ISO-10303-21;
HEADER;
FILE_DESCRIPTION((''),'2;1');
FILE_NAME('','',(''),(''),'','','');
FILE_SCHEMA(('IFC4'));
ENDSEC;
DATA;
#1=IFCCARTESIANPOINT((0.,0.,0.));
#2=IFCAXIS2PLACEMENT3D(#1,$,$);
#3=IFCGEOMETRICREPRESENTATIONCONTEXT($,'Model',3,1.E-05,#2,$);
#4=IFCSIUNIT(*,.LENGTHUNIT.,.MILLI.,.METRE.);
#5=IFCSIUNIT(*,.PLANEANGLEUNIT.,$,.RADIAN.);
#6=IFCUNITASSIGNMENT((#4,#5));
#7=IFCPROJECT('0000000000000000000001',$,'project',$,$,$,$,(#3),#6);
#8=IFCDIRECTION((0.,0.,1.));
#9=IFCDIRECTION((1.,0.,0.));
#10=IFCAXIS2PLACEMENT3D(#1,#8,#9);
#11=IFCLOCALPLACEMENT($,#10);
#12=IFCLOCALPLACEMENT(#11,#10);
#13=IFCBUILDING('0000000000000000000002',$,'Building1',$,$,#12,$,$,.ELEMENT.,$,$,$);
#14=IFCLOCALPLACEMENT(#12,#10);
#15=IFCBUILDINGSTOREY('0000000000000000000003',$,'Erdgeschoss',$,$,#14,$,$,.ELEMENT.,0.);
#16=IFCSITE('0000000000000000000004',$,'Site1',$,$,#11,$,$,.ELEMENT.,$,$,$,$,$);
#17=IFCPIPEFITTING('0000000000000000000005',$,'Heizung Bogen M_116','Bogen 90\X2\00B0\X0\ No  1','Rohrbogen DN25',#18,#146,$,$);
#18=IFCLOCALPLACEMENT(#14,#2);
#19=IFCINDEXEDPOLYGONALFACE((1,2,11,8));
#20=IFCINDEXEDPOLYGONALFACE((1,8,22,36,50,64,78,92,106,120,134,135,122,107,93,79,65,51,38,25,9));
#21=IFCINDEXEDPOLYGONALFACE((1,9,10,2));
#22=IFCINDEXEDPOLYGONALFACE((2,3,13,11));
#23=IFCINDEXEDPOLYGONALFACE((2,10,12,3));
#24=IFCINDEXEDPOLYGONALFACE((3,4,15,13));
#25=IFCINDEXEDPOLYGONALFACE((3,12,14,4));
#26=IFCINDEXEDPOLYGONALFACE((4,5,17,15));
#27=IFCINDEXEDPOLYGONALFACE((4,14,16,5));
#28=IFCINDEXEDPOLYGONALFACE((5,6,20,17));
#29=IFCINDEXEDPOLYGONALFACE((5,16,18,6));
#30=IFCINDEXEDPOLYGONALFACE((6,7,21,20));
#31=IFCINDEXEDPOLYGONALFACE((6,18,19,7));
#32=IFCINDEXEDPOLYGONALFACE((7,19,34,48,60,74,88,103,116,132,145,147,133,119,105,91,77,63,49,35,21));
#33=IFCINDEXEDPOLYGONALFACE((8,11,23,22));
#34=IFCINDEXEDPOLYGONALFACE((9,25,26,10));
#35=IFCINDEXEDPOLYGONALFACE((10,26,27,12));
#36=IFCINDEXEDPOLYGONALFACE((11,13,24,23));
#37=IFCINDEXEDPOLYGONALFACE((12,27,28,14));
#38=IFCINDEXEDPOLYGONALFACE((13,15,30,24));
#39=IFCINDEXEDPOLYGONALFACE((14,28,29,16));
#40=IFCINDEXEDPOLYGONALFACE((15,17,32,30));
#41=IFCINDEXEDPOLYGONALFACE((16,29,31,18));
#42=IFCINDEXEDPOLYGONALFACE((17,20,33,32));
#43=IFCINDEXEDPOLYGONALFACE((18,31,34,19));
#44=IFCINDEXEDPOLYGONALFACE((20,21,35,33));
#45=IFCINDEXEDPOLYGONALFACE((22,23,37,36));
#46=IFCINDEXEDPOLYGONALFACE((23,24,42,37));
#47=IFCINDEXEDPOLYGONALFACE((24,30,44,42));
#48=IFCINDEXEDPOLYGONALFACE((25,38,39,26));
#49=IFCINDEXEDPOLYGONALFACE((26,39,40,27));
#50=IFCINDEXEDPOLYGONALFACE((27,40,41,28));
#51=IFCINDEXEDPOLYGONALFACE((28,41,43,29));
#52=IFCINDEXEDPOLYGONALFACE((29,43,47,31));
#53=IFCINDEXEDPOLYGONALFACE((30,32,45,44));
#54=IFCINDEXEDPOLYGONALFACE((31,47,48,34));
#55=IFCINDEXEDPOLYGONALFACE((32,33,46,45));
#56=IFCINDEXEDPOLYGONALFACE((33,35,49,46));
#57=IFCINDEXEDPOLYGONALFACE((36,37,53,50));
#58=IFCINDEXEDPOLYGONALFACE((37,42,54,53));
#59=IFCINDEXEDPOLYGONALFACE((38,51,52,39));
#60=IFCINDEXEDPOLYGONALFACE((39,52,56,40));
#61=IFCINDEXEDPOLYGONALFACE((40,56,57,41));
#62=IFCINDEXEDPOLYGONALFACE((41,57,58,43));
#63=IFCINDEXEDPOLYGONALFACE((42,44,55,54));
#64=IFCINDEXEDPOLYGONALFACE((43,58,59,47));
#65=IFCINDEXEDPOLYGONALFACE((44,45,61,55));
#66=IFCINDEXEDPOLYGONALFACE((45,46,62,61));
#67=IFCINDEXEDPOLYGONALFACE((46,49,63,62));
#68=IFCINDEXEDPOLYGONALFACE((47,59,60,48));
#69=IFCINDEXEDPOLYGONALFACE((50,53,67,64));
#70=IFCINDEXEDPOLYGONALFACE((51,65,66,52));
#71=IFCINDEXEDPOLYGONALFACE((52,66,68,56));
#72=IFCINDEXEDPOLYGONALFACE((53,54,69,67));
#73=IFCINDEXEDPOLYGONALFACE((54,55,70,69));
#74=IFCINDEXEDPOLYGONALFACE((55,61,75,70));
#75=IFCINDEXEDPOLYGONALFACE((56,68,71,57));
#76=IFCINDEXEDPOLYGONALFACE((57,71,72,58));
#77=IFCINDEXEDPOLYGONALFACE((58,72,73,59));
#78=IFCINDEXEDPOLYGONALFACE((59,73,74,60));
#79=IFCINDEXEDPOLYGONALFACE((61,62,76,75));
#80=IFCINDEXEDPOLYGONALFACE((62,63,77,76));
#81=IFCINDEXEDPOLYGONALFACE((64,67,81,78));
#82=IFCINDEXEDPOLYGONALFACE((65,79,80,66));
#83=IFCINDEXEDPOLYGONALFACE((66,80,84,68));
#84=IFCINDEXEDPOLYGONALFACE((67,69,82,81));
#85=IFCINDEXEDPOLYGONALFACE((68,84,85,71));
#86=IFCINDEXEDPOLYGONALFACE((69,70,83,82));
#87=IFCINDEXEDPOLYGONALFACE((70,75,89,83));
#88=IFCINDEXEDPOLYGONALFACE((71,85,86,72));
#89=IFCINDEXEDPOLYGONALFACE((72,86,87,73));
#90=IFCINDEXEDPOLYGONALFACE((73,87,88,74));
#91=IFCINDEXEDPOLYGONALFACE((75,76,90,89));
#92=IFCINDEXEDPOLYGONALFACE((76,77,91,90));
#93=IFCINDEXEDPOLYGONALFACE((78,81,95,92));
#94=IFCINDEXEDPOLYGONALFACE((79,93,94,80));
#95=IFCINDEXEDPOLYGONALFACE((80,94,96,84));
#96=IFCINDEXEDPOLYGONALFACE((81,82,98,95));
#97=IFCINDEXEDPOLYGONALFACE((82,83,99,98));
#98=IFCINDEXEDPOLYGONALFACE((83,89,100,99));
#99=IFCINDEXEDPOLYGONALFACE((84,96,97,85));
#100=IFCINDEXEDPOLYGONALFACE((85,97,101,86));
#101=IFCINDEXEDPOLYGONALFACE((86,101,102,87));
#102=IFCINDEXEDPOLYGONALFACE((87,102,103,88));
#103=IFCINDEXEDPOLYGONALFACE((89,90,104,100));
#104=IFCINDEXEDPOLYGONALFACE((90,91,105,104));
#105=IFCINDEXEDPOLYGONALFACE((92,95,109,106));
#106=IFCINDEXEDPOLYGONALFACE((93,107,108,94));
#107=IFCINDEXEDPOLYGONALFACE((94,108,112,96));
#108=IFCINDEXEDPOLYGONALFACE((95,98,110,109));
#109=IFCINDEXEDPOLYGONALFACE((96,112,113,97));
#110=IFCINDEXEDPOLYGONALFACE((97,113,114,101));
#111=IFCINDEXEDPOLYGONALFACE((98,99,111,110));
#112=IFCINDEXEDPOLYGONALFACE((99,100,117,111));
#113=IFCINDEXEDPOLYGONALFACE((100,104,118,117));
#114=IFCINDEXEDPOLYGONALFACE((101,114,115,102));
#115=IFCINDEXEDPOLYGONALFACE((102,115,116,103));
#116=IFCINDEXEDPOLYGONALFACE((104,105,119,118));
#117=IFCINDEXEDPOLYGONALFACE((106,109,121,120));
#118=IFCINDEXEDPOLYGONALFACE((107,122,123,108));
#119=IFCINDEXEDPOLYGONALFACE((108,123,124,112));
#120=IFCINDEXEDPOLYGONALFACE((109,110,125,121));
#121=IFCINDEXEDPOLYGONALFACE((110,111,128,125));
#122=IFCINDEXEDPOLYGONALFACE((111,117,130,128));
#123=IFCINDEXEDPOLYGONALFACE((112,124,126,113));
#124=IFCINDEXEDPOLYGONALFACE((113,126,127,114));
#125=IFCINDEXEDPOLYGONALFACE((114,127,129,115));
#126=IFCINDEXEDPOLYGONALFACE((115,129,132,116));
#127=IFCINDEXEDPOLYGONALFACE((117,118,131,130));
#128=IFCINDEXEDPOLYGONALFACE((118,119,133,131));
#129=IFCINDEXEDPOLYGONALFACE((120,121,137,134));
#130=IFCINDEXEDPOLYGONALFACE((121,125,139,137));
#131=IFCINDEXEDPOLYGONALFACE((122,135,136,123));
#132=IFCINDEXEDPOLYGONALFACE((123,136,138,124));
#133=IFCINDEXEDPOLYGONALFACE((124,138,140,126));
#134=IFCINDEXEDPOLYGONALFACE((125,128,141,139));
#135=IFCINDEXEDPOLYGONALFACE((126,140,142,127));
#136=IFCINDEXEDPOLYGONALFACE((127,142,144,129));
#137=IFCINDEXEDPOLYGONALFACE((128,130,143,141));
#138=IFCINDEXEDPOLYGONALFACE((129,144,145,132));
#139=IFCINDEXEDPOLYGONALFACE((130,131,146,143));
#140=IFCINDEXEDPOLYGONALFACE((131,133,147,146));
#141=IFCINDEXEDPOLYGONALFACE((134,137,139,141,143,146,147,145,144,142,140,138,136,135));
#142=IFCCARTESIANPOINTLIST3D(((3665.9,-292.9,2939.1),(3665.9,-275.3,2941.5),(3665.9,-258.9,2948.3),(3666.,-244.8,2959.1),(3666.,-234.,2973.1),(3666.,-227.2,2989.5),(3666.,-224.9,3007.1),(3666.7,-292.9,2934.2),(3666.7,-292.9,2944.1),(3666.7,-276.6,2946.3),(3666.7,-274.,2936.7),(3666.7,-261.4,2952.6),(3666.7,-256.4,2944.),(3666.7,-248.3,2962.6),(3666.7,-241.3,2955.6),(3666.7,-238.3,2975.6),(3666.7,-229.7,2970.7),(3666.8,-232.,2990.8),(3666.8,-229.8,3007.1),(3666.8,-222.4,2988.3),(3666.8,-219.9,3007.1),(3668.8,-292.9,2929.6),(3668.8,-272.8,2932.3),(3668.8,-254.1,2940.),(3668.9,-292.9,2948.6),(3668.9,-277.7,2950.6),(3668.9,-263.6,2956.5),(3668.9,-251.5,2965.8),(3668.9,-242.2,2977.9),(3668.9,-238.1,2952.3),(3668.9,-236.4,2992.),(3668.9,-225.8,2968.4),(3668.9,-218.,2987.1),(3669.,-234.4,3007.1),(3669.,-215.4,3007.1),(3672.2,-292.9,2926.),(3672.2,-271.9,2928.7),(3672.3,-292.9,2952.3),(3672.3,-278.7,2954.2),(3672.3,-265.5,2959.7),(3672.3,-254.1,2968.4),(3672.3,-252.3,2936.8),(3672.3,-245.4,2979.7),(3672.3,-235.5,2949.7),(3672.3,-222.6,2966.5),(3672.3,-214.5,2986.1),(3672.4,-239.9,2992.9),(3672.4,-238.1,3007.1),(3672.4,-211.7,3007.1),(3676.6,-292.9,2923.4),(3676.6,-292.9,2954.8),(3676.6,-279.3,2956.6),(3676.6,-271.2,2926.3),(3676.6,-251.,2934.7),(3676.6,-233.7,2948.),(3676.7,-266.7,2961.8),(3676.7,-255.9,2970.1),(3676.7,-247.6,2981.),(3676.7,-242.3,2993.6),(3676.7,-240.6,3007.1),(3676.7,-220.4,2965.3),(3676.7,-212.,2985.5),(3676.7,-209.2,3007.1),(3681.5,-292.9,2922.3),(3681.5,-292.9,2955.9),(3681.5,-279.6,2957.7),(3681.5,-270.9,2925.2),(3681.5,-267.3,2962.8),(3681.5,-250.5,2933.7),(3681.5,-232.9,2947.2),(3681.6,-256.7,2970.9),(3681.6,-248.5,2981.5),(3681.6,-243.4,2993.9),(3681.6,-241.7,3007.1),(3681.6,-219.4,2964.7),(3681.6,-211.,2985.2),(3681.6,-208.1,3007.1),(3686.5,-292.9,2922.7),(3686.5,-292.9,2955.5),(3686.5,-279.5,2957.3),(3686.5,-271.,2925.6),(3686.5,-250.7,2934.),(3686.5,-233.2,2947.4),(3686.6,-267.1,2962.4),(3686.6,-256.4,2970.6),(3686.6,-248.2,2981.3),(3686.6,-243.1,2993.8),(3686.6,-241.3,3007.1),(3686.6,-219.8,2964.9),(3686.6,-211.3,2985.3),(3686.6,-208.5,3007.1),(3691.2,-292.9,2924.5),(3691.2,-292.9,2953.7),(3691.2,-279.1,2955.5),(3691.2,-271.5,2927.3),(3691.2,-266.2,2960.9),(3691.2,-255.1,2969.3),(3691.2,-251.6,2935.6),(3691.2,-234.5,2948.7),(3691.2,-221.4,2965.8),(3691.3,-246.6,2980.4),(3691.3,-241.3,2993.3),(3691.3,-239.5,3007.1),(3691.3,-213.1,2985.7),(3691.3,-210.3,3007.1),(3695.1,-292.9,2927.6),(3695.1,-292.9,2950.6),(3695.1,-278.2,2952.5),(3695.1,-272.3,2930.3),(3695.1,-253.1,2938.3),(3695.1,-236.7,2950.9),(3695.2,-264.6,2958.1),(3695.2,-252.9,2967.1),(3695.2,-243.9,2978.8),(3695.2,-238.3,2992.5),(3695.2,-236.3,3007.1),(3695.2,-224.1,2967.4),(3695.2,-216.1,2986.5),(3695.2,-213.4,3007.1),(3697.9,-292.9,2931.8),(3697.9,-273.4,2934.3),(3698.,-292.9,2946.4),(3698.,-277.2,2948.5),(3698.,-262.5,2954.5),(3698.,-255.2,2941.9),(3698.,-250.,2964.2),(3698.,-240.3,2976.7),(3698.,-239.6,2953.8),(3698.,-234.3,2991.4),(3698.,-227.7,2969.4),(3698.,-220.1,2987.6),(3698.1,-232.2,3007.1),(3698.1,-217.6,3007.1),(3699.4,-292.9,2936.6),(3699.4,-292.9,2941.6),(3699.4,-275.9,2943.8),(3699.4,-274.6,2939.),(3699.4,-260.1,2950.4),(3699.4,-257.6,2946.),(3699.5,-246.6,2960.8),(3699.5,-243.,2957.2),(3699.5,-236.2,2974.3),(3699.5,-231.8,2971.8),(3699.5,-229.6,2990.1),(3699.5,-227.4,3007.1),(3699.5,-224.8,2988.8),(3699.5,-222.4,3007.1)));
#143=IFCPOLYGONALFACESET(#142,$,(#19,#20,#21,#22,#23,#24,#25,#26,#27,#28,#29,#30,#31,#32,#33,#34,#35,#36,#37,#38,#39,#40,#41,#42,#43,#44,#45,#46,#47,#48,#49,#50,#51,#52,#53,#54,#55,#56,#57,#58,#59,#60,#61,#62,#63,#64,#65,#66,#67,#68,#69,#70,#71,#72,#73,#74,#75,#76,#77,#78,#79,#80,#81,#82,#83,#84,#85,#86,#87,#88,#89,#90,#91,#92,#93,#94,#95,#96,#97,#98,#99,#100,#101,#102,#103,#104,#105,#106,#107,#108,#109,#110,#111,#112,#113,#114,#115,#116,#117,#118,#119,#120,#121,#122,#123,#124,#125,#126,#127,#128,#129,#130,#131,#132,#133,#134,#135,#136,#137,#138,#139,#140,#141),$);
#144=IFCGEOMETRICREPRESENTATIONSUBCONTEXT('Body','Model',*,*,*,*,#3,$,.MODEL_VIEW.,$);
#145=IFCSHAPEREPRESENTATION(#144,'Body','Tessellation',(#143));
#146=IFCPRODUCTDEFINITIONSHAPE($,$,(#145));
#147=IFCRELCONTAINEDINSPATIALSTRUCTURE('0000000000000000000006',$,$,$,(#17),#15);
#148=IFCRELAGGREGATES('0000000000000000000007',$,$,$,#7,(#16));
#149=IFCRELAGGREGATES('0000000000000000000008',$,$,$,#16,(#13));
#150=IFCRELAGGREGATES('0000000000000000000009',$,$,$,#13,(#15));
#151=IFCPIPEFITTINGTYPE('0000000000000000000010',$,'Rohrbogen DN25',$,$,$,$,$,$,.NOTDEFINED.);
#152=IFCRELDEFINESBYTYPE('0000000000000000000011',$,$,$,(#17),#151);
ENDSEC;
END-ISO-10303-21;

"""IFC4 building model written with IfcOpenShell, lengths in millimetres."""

from ifc_helpers import new_model, entity, si_unit, frame, origin, origin_with_axes, place, context, subcontext, project, spatial, source, transform, mapped, type_object, element, save


model = new_model("IFC4")

# Units and contexts
model_context = context("Model", 3, precision=1e-05, world=origin())
body_context = subcontext(model_context, "Body", "Model", "MODEL_VIEW")
ifc_project = project(units=[si_unit("LENGTHUNIT", "METRE", prefix="MILLI"), si_unit("PLANEANGLEUNIT", "RADIAN")], contexts=[model_context])

# Site, building, storey
site_placement = place(None, origin_with_axes())
site = spatial("IfcSite", under=ifc_project, at=site_placement, Name="Site1", CompositionType="ELEMENT")
building_placement = place(site_placement, origin_with_axes())
building = spatial("IfcBuilding", under=site, at=building_placement, Name="Building1", CompositionType="ELEMENT")
storey_placement = place(building_placement, origin_with_axes())
storey = spatial("IfcBuildingStorey", under=building, at=storey_placement, Name="Erdgeschoss", CompositionType="ELEMENT", Elevation=0.0)

# Shared definitions
pipe_fitting_type_1 = type_object("IfcPipeFittingType", Name="Rohrbogen DN25", PredefinedType="NOTDEFINED")

# Pipe fitting
shared_shape_1 = source(origin_with_axes(), body_context, "Body", "SolidModel", [
    entity("IfcRevolvedAreaSolid", entity("IfcCircleProfileDef", "AREA", None, entity("IfcAxis2Placement2D", entity("IfcCartesianPoint", [0.0, 0.0]), entity("IfcDirection", [1.0, 0.0])), 16.9), entity("IfcAxis2Placement3D", entity("IfcCartesianPoint", [-42.4, 0.0, -25.6]), entity("IfcDirection", [1.0, 0.0, 0.0]), entity("IfcDirection", [0.0, 0.999999, 0.00173])), entity("IfcAxis1Placement", entity("IfcCartesianPoint", [0.0, 68.0, 0.0]), entity("IfcDirection", [-1.0, 0.0, 0.0])), 1.570796),
])
pipe_fitting_1_placement = place(storey_placement, frame((3682.8, -250.5, 2964.7), z_axis=(0.0, 0.0, 1.0), x_axis=(1.0, 0.0, 0.0)))
element("IfcPipeFitting", 1, at=pipe_fitting_1_placement, inside=storey, type_object=pipe_fitting_type_1, Name="Heizung Bogen M_116", Description="Bogen 90° No  1", ObjectType="Rohrbogen DN25", context=body_context, shape_type="MappedRepresentation", body=[
    mapped(shared_shape_1, transform((0.0, 0.0, 0.0), x_axis=(0.0, 1.0, 0.0), y_axis=(-1.0, 0.0, 0.0), z_axis=(0.0, 0.0, 1.0), scale=1.0)),
])

save(model, "model.ifc")
